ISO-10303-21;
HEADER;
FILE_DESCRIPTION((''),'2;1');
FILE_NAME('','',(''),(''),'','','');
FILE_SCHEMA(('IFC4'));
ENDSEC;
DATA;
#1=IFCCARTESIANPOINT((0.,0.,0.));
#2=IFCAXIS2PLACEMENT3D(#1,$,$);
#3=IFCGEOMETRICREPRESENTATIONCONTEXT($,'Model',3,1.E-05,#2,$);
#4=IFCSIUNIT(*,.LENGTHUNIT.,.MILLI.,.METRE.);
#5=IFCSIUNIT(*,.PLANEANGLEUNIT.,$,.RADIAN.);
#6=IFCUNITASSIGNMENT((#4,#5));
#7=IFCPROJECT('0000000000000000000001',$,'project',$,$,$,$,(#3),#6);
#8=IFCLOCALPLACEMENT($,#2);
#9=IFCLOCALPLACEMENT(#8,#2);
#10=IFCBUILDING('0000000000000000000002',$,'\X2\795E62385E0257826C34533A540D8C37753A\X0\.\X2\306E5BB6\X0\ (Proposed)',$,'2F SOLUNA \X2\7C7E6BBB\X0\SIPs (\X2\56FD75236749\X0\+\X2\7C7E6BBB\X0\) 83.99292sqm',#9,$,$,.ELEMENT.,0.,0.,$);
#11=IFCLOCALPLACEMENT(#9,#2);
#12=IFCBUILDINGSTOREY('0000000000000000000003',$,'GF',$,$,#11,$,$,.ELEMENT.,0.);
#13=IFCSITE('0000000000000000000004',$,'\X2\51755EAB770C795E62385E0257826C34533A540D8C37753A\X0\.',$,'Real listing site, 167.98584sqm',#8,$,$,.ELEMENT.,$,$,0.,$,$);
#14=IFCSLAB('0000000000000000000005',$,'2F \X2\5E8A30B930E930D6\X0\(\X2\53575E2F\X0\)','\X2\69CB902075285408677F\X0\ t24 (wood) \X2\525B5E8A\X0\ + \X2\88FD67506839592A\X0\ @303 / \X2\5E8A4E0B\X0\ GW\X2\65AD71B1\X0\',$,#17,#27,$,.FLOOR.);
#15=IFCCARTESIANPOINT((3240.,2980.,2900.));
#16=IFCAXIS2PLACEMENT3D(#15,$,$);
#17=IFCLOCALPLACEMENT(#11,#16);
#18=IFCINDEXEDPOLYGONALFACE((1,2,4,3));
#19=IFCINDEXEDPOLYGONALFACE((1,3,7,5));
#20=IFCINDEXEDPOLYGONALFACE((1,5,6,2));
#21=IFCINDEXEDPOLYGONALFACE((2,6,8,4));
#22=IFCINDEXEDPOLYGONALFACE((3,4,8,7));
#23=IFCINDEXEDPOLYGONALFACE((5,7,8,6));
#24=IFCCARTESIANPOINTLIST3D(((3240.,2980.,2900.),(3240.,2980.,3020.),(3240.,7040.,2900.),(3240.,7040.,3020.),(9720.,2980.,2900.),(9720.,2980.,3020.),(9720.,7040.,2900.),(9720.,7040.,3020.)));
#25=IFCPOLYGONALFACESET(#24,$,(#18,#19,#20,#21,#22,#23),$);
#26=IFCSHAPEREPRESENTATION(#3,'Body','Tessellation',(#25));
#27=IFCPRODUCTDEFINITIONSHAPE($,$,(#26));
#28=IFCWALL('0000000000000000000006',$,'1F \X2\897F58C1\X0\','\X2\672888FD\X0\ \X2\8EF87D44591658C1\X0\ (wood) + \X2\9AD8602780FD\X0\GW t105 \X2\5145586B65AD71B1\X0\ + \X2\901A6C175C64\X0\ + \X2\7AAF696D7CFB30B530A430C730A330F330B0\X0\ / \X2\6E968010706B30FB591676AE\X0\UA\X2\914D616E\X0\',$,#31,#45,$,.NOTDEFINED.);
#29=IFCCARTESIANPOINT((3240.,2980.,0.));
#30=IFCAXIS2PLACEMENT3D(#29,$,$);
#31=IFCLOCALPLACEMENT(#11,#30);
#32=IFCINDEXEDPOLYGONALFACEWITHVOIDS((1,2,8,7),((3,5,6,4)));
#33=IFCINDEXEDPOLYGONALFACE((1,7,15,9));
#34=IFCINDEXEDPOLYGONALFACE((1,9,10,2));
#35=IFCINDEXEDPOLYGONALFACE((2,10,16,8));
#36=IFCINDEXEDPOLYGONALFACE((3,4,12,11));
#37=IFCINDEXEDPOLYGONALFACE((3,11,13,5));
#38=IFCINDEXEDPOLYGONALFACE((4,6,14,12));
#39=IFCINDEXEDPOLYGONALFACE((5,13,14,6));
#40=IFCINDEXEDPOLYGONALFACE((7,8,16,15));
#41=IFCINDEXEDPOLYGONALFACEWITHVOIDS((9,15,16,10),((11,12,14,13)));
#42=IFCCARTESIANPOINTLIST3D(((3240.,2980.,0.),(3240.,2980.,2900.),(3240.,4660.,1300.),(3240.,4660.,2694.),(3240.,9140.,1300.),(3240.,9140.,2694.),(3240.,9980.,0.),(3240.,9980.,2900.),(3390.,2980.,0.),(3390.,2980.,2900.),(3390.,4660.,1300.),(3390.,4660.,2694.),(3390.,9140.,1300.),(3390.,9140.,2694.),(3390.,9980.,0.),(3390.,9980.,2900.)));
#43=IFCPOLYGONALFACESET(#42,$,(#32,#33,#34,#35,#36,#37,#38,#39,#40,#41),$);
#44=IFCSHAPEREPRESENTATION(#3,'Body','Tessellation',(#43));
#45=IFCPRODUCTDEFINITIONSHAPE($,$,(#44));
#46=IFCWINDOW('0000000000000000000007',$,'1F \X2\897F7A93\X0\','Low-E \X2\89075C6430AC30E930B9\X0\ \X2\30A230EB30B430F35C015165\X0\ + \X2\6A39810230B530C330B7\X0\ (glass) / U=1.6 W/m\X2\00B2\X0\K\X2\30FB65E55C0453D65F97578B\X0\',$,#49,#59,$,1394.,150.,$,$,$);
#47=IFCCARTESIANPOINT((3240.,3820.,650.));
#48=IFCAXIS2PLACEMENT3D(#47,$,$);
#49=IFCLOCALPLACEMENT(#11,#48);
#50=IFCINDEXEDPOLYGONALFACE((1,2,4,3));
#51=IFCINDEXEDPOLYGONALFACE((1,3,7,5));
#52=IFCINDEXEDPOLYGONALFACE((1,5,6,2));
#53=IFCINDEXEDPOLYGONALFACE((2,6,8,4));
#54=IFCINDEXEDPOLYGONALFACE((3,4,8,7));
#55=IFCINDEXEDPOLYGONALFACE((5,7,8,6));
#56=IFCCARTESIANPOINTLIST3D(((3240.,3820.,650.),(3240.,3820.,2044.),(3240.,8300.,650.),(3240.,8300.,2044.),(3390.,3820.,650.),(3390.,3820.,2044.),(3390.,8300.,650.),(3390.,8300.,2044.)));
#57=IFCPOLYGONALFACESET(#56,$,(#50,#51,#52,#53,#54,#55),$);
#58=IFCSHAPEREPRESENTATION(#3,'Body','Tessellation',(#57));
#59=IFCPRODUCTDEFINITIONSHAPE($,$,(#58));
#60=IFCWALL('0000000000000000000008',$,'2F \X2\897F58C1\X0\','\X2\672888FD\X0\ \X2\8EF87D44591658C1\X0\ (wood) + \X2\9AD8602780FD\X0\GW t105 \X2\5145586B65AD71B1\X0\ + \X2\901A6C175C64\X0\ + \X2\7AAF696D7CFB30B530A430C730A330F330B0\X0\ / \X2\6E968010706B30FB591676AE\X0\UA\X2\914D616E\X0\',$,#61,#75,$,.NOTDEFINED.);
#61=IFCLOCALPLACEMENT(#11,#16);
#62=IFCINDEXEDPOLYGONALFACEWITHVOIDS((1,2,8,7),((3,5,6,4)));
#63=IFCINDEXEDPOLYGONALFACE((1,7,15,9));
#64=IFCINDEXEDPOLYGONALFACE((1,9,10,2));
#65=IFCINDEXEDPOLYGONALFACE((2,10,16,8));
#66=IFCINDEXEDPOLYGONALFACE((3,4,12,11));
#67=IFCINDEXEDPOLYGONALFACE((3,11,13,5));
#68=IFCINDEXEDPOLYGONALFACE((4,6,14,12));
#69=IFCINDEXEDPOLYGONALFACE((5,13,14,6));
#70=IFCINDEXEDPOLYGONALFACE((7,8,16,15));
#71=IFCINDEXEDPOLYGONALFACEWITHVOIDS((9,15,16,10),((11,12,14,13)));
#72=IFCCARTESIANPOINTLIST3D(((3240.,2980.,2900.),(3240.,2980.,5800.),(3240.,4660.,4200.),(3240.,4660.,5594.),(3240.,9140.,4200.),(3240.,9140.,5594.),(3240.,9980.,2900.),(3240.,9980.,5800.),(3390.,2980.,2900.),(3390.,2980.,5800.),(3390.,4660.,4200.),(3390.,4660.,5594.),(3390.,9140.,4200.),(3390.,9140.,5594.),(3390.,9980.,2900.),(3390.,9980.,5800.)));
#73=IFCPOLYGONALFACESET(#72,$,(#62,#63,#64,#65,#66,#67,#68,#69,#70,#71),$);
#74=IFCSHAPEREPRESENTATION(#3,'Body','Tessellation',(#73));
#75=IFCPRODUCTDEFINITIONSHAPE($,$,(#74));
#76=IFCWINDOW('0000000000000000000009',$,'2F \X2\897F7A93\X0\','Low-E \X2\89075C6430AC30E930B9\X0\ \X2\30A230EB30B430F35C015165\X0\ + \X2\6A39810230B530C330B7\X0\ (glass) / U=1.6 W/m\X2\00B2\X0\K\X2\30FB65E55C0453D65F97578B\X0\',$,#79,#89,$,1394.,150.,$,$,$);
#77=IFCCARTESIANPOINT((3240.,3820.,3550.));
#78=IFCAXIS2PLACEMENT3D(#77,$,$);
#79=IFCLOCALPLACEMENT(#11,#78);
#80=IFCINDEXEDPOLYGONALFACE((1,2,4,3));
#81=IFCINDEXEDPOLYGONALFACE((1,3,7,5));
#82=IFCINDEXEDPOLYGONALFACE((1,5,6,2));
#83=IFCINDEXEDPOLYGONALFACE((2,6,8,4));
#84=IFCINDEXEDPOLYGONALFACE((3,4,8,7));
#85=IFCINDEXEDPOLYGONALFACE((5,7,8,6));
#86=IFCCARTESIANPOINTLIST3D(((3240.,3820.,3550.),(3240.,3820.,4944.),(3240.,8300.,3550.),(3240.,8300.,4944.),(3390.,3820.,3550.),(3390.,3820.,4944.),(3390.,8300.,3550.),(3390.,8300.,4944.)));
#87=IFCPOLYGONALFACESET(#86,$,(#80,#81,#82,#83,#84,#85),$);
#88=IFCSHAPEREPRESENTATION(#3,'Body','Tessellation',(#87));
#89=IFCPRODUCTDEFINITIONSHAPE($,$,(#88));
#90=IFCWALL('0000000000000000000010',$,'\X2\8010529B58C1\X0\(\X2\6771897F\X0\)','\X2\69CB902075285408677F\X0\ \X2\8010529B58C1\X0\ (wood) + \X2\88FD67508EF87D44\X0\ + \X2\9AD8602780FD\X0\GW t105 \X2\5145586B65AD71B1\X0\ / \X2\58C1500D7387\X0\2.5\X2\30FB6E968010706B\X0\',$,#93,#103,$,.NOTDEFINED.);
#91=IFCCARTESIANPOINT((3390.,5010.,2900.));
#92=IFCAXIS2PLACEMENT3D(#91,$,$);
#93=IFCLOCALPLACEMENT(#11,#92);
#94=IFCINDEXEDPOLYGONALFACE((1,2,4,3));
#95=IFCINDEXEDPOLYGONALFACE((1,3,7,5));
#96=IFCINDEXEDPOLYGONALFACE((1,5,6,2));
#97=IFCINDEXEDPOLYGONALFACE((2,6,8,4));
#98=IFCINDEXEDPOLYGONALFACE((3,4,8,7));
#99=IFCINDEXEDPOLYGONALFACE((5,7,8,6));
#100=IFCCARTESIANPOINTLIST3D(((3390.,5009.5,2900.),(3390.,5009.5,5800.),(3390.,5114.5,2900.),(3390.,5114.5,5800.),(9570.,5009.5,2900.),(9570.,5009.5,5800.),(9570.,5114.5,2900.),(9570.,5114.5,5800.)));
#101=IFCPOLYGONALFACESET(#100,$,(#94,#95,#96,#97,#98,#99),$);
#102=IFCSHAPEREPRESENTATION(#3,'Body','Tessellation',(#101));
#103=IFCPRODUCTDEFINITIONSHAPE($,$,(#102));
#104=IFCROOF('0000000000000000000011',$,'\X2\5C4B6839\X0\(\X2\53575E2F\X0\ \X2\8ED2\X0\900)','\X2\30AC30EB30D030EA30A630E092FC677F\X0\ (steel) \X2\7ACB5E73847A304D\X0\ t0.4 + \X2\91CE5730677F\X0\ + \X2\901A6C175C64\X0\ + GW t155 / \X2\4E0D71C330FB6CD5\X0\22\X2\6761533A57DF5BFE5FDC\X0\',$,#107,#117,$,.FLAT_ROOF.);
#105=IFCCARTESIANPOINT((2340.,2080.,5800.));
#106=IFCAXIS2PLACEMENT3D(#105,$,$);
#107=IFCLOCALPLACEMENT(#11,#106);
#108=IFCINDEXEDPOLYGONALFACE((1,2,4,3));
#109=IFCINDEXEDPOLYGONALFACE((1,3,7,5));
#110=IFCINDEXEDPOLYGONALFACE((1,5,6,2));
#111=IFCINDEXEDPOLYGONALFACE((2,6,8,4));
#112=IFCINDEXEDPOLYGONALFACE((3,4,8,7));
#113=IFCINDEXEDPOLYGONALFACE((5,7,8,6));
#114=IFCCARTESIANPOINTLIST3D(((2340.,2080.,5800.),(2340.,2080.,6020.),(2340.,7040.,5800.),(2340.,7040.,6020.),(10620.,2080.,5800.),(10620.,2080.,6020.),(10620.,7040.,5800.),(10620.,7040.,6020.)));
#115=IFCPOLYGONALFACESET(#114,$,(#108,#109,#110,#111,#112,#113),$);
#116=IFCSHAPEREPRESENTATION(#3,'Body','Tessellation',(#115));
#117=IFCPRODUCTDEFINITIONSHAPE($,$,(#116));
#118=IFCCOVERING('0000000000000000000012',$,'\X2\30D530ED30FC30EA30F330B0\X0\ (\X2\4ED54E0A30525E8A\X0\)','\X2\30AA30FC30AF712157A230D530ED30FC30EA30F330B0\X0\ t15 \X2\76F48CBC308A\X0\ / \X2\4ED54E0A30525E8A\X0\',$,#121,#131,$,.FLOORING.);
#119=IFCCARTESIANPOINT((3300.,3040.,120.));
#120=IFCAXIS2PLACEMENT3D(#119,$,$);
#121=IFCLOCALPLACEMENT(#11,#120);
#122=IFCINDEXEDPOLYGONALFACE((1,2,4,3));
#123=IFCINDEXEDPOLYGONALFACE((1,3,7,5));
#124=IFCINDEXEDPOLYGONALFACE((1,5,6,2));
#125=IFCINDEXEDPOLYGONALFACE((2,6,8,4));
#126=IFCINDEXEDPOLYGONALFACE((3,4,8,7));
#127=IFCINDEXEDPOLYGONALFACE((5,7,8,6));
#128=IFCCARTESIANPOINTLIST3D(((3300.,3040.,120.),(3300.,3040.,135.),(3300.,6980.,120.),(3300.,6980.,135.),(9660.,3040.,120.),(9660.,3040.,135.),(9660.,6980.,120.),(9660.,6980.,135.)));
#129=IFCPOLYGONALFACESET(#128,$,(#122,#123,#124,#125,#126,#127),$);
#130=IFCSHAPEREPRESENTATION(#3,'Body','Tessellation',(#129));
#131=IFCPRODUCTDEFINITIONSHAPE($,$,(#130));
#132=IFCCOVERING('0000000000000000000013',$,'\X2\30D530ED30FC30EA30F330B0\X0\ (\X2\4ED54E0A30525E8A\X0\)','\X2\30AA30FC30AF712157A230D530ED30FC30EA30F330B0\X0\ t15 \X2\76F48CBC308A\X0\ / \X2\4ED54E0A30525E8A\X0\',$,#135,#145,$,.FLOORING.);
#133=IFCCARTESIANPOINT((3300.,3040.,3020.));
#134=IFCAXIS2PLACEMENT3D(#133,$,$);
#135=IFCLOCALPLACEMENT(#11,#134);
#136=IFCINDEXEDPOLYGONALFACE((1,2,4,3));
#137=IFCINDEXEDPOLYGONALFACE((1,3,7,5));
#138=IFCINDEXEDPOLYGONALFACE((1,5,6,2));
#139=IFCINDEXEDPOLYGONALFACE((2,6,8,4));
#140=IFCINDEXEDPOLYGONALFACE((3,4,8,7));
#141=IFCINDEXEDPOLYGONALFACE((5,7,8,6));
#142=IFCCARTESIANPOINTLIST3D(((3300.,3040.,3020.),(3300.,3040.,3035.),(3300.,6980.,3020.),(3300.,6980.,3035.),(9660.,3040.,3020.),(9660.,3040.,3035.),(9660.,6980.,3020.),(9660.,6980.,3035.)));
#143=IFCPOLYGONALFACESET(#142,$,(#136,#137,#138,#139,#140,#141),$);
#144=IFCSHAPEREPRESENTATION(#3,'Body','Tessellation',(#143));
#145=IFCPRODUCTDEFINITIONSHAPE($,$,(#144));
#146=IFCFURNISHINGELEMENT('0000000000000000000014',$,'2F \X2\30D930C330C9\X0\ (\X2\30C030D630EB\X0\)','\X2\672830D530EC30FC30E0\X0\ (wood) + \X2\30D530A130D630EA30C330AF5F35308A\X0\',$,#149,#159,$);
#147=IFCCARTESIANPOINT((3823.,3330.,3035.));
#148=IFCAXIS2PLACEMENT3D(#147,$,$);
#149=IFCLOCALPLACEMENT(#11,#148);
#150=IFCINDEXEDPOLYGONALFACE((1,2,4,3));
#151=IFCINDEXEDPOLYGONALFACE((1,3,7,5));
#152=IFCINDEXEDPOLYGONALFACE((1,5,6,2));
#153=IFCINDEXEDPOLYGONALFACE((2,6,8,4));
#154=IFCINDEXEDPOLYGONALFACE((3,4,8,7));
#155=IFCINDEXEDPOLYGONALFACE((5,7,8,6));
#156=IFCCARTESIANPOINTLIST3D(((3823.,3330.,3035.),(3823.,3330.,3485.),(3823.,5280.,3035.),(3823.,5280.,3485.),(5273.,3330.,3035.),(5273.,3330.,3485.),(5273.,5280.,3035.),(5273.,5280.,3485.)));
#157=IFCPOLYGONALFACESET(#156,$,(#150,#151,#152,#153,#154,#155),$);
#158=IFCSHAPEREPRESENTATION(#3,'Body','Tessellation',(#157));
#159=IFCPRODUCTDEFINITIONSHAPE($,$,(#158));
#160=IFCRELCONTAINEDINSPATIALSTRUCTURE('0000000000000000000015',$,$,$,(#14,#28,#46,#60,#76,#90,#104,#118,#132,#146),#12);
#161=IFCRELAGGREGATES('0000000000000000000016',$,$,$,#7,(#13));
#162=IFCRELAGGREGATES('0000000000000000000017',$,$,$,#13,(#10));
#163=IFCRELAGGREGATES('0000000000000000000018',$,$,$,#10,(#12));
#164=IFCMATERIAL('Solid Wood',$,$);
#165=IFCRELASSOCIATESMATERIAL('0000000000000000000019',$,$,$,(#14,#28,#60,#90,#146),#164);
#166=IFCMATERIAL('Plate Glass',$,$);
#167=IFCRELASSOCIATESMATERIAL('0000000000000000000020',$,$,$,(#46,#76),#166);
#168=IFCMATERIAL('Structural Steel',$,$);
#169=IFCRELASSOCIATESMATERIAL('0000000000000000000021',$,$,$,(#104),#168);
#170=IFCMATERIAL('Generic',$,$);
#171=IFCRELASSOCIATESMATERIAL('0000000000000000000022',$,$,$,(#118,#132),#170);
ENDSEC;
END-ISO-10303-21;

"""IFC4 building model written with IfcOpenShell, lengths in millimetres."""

from ifc_helpers import new_model, si_unit, frame, frame_2d, origin, place, context, project, spatial, rectangle, extrude, material, element, fill, save


model = new_model("IFC4")

# Units and contexts
model_context = context("Model", 3, precision=1e-05, world=origin())
ifc_project = project(units=[si_unit("LENGTHUNIT", "METRE", prefix="MILLI"), si_unit("PLANEANGLEUNIT", "RADIAN")], contexts=[model_context])

# Site, building, storey
site_placement = place(None, origin())
site = spatial("IfcSite", under=ifc_project, at=site_placement, Name="兵庫県神戸市垂水区名谷町.", ObjectType="Real listing site, 167.98584sqm", CompositionType="ELEMENT", RefElevation=0.0)
building_placement = place(site_placement, origin())
building = spatial("IfcBuilding", under=site, at=building_placement, Name="神戸市垂水区名谷町.の家 (Proposed)", ObjectType="2F SOLUNA 籾殻SIPs (国産杉+籾殻) 83.99292sqm", CompositionType="ELEMENT", ElevationOfRefHeight=0.0, ElevationOfTerrain=0.0)
storey_placement = place(building_placement, origin())
storey = spatial("IfcBuildingStorey", under=building, at=storey_placement, Name="GF", CompositionType="ELEMENT", Elevation=0.0)

# Slab
ifc_material_1 = material(Name="Solid Wood")
slab_1_placement = place(storey_placement, frame((3240.0, 2980.0, 2900.0)))
element("IfcSlab", 1, at=slab_1_placement, inside=storey, material=ifc_material_1, Name="2F 床スラブ(南帯)", Description="構造用合板 t24 (wood) 剛床 + 製材根太 @303 / 床下 GW断熱", PredefinedType="FLOOR", context=model_context, shape_type="SweptSolid", body=[
    extrude(rectangle(XDim=6480.0, YDim=4060.0, at=frame_2d((3240.0, 2030.0))), frame((3240.0, 2980.0, 2900.0)), (0.0, 0.0, 1.0), 120.0),
])

# Shared definitions
ifc_material_2 = material(Name="Plate Glass")

# Wall, opening, window
wall_1_placement = place(storey_placement, frame((3240.0, 2980.0, 0.0)))
wall_1 = element("IfcWall", 2, at=wall_1_placement, inside=storey, material=ifc_material_1, Name="1F 西壁", Description="木製 軸組外壁 (wood) + 高性能GW t105 充填断熱 + 通気層 + 窯業系サイディング / 準耐火・外皮UA配慮", PredefinedType="NOTDEFINED", context=model_context, shape_type="SweptSolid", body=[
    extrude(rectangle(XDim=150.0, YDim=7000.0, at=frame_2d((75.0, 3500.0))), frame((3240.0, 2980.0, 0.0)), (0.0, 0.0, 1.0), 2900.0),
])
opening_1_placement = place(storey_placement, frame((3240.0, 3820.0, 650.0)))
opening_1 = element("IfcOpeningElement", 3, at=opening_1_placement, cuts=wall_1, PredefinedType="NOTDEFINED", context=model_context, shape_type="SweptSolid", body=[
    extrude(rectangle(XDim=150.0, YDim=4480.0, at=frame_2d((75.0, 2240.0))), frame((3240.0, 3820.0, 650.0)), (0.0, 0.0, 1.0), 1394.0),
])
window_1_placement = place(storey_placement, frame((3240.0, 3820.0, 650.0)))
window_1 = element("IfcWindow", 4, at=window_1_placement, inside=storey, material=ifc_material_2, Name="1F 西窓", Description="Low-E 複層ガラス アルゴン封入 + 樹脂サッシ (glass) / U=1.6 W/m²K・日射取得型", OverallHeight=1394.0, OverallWidth=150.0, context=model_context, shape_type="SweptSolid", body=[
    extrude(rectangle(XDim=150.0, YDim=4480.0, at=frame_2d((75.0, 2240.0))), frame((3240.0, 3820.0, 650.0)), (0.0, 0.0, 1.0), 1394.0),
])
fill(opening_1, window_1)

# Wall, opening, window
wall_2_placement = place(storey_placement, frame((3240.0, 2980.0, 2900.0)))
wall_2 = element("IfcWall", 5, at=wall_2_placement, inside=storey, material=ifc_material_1, Name="2F 西壁", Description="木製 軸組外壁 (wood) + 高性能GW t105 充填断熱 + 通気層 + 窯業系サイディング / 準耐火・外皮UA配慮", PredefinedType="NOTDEFINED", context=model_context, shape_type="SweptSolid", body=[
    extrude(rectangle(XDim=150.0, YDim=7000.0, at=frame_2d((75.0, 3500.0))), frame((3240.0, 2980.0, 2900.0)), (0.0, 0.0, 1.0), 2900.0),
])
opening_2_placement = place(storey_placement, frame((3240.0, 3820.0, 3550.0)))
opening_2 = element("IfcOpeningElement", 6, at=opening_2_placement, cuts=wall_2, PredefinedType="NOTDEFINED", context=model_context, shape_type="SweptSolid", body=[
    extrude(rectangle(XDim=150.0, YDim=4480.0, at=frame_2d((75.0, 2240.0))), frame((3240.0, 3820.0, 3550.0)), (0.0, 0.0, 1.0), 1394.0),
])
window_2_placement = place(storey_placement, frame((3240.0, 3820.0, 3550.0)))
window_2 = element("IfcWindow", 7, at=window_2_placement, inside=storey, material=ifc_material_2, Name="2F 西窓", Description="Low-E 複層ガラス アルゴン封入 + 樹脂サッシ (glass) / U=1.6 W/m²K・日射取得型", OverallHeight=1394.0, OverallWidth=150.0, context=model_context, shape_type="SweptSolid", body=[
    extrude(rectangle(XDim=150.0, YDim=4480.0, at=frame_2d((75.0, 2240.0))), frame((3240.0, 3820.0, 3550.0)), (0.0, 0.0, 1.0), 1394.0),
])
fill(opening_2, window_2)

# Wall
wall_3_placement = place(storey_placement, frame((3390.0, 5010.0, 2900.0)))
element("IfcWall", 8, at=wall_3_placement, inside=storey, material=ifc_material_1, Name="耐力壁(東西)", Description="構造用合板 耐力壁 (wood) + 製材軸組 + 高性能GW t105 充填断熱 / 壁倍率2.5・準耐火", PredefinedType="NOTDEFINED", context=model_context, shape_type="SweptSolid", body=[
    extrude(rectangle(XDim=6180.0, YDim=105.0, at=frame_2d((3090.0, 52.0))), frame((3390.0, 5010.0, 2900.0)), (0.0, 0.0, 1.0), 2900.0),
])

# Roof
ifc_material_3 = material(Name="Structural Steel")
for number, where, name in (
    (9, (2340.0, 2080.0, 5800.0), "屋根(南帯 軒900)"),
):
    element("IfcRoof", number, at=place(storey_placement, frame(where)), inside=storey, material=ifc_material_3, Name=name, Description="ガルバリウム鋼板 (steel) 立平葺き t0.4 + 野地板 + 通気層 + GW t155 / 不燃・法22条区域対応", PredefinedType="FLAT_ROOF", context=model_context, shape_type="SweptSolid", body=[
        extrude(rectangle(XDim=8280.0, YDim=4960.0, at=frame_2d((4140.0, 2480.0))), frame((2340.0, 2080.0, 5800.0)), (0.0, 0.0, 1.0), 220.0),
    ])

# Coverings
ifc_material_4 = material(Name="Generic")
covering_1_placement = place(storey_placement, frame((3300.0, 3040.0, 120.0)))
element("IfcCovering", 10, at=covering_1_placement, inside=storey, material=ifc_material_4, Name="フローリング (仕上げ床)", Description="オーク無垢フローリング t15 直貼り / 仕上げ床", PredefinedType="FLOORING", context=model_context, shape_type="SweptSolid", body=[
    extrude(rectangle(XDim=6360.0, YDim=3940.0, at=frame_2d((3180.0, 1970.0))), frame((3300.0, 3040.0, 120.0)), (0.0, 0.0, 1.0), 15.0),
])
covering_2_placement = place(storey_placement, frame((3300.0, 3040.0, 3020.0)))
element("IfcCovering", 11, at=covering_2_placement, inside=storey, material=ifc_material_4, Name="フローリング (仕上げ床)", Description="オーク無垢フローリング t15 直貼り / 仕上げ床", PredefinedType="FLOORING", context=model_context, shape_type="SweptSolid", body=[
    extrude(rectangle(XDim=6360.0, YDim=3940.0, at=frame_2d((3180.0, 1970.0))), frame((3300.0, 3040.0, 3020.0)), (0.0, 0.0, 1.0), 15.0),
])

# Furnishing element
furnishing_placement = place(storey_placement, frame((3823.0, 3330.0, 3035.0)))
element("IfcFurnishingElement", 12, at=furnishing_placement, inside=storey, material=ifc_material_1, Name="2F ベッド (ダブル)", Description="木フレーム (wood) + ファブリック張り", context=model_context, shape_type="SweptSolid", body=[
    extrude(rectangle(XDim=1450.0, YDim=1950.0, at=frame_2d((725.0, 975.0))), frame((3823.0, 3330.0, 3035.0)), (0.0, 0.0, 1.0), 450.0),
])

save(model, "model.ifc")
